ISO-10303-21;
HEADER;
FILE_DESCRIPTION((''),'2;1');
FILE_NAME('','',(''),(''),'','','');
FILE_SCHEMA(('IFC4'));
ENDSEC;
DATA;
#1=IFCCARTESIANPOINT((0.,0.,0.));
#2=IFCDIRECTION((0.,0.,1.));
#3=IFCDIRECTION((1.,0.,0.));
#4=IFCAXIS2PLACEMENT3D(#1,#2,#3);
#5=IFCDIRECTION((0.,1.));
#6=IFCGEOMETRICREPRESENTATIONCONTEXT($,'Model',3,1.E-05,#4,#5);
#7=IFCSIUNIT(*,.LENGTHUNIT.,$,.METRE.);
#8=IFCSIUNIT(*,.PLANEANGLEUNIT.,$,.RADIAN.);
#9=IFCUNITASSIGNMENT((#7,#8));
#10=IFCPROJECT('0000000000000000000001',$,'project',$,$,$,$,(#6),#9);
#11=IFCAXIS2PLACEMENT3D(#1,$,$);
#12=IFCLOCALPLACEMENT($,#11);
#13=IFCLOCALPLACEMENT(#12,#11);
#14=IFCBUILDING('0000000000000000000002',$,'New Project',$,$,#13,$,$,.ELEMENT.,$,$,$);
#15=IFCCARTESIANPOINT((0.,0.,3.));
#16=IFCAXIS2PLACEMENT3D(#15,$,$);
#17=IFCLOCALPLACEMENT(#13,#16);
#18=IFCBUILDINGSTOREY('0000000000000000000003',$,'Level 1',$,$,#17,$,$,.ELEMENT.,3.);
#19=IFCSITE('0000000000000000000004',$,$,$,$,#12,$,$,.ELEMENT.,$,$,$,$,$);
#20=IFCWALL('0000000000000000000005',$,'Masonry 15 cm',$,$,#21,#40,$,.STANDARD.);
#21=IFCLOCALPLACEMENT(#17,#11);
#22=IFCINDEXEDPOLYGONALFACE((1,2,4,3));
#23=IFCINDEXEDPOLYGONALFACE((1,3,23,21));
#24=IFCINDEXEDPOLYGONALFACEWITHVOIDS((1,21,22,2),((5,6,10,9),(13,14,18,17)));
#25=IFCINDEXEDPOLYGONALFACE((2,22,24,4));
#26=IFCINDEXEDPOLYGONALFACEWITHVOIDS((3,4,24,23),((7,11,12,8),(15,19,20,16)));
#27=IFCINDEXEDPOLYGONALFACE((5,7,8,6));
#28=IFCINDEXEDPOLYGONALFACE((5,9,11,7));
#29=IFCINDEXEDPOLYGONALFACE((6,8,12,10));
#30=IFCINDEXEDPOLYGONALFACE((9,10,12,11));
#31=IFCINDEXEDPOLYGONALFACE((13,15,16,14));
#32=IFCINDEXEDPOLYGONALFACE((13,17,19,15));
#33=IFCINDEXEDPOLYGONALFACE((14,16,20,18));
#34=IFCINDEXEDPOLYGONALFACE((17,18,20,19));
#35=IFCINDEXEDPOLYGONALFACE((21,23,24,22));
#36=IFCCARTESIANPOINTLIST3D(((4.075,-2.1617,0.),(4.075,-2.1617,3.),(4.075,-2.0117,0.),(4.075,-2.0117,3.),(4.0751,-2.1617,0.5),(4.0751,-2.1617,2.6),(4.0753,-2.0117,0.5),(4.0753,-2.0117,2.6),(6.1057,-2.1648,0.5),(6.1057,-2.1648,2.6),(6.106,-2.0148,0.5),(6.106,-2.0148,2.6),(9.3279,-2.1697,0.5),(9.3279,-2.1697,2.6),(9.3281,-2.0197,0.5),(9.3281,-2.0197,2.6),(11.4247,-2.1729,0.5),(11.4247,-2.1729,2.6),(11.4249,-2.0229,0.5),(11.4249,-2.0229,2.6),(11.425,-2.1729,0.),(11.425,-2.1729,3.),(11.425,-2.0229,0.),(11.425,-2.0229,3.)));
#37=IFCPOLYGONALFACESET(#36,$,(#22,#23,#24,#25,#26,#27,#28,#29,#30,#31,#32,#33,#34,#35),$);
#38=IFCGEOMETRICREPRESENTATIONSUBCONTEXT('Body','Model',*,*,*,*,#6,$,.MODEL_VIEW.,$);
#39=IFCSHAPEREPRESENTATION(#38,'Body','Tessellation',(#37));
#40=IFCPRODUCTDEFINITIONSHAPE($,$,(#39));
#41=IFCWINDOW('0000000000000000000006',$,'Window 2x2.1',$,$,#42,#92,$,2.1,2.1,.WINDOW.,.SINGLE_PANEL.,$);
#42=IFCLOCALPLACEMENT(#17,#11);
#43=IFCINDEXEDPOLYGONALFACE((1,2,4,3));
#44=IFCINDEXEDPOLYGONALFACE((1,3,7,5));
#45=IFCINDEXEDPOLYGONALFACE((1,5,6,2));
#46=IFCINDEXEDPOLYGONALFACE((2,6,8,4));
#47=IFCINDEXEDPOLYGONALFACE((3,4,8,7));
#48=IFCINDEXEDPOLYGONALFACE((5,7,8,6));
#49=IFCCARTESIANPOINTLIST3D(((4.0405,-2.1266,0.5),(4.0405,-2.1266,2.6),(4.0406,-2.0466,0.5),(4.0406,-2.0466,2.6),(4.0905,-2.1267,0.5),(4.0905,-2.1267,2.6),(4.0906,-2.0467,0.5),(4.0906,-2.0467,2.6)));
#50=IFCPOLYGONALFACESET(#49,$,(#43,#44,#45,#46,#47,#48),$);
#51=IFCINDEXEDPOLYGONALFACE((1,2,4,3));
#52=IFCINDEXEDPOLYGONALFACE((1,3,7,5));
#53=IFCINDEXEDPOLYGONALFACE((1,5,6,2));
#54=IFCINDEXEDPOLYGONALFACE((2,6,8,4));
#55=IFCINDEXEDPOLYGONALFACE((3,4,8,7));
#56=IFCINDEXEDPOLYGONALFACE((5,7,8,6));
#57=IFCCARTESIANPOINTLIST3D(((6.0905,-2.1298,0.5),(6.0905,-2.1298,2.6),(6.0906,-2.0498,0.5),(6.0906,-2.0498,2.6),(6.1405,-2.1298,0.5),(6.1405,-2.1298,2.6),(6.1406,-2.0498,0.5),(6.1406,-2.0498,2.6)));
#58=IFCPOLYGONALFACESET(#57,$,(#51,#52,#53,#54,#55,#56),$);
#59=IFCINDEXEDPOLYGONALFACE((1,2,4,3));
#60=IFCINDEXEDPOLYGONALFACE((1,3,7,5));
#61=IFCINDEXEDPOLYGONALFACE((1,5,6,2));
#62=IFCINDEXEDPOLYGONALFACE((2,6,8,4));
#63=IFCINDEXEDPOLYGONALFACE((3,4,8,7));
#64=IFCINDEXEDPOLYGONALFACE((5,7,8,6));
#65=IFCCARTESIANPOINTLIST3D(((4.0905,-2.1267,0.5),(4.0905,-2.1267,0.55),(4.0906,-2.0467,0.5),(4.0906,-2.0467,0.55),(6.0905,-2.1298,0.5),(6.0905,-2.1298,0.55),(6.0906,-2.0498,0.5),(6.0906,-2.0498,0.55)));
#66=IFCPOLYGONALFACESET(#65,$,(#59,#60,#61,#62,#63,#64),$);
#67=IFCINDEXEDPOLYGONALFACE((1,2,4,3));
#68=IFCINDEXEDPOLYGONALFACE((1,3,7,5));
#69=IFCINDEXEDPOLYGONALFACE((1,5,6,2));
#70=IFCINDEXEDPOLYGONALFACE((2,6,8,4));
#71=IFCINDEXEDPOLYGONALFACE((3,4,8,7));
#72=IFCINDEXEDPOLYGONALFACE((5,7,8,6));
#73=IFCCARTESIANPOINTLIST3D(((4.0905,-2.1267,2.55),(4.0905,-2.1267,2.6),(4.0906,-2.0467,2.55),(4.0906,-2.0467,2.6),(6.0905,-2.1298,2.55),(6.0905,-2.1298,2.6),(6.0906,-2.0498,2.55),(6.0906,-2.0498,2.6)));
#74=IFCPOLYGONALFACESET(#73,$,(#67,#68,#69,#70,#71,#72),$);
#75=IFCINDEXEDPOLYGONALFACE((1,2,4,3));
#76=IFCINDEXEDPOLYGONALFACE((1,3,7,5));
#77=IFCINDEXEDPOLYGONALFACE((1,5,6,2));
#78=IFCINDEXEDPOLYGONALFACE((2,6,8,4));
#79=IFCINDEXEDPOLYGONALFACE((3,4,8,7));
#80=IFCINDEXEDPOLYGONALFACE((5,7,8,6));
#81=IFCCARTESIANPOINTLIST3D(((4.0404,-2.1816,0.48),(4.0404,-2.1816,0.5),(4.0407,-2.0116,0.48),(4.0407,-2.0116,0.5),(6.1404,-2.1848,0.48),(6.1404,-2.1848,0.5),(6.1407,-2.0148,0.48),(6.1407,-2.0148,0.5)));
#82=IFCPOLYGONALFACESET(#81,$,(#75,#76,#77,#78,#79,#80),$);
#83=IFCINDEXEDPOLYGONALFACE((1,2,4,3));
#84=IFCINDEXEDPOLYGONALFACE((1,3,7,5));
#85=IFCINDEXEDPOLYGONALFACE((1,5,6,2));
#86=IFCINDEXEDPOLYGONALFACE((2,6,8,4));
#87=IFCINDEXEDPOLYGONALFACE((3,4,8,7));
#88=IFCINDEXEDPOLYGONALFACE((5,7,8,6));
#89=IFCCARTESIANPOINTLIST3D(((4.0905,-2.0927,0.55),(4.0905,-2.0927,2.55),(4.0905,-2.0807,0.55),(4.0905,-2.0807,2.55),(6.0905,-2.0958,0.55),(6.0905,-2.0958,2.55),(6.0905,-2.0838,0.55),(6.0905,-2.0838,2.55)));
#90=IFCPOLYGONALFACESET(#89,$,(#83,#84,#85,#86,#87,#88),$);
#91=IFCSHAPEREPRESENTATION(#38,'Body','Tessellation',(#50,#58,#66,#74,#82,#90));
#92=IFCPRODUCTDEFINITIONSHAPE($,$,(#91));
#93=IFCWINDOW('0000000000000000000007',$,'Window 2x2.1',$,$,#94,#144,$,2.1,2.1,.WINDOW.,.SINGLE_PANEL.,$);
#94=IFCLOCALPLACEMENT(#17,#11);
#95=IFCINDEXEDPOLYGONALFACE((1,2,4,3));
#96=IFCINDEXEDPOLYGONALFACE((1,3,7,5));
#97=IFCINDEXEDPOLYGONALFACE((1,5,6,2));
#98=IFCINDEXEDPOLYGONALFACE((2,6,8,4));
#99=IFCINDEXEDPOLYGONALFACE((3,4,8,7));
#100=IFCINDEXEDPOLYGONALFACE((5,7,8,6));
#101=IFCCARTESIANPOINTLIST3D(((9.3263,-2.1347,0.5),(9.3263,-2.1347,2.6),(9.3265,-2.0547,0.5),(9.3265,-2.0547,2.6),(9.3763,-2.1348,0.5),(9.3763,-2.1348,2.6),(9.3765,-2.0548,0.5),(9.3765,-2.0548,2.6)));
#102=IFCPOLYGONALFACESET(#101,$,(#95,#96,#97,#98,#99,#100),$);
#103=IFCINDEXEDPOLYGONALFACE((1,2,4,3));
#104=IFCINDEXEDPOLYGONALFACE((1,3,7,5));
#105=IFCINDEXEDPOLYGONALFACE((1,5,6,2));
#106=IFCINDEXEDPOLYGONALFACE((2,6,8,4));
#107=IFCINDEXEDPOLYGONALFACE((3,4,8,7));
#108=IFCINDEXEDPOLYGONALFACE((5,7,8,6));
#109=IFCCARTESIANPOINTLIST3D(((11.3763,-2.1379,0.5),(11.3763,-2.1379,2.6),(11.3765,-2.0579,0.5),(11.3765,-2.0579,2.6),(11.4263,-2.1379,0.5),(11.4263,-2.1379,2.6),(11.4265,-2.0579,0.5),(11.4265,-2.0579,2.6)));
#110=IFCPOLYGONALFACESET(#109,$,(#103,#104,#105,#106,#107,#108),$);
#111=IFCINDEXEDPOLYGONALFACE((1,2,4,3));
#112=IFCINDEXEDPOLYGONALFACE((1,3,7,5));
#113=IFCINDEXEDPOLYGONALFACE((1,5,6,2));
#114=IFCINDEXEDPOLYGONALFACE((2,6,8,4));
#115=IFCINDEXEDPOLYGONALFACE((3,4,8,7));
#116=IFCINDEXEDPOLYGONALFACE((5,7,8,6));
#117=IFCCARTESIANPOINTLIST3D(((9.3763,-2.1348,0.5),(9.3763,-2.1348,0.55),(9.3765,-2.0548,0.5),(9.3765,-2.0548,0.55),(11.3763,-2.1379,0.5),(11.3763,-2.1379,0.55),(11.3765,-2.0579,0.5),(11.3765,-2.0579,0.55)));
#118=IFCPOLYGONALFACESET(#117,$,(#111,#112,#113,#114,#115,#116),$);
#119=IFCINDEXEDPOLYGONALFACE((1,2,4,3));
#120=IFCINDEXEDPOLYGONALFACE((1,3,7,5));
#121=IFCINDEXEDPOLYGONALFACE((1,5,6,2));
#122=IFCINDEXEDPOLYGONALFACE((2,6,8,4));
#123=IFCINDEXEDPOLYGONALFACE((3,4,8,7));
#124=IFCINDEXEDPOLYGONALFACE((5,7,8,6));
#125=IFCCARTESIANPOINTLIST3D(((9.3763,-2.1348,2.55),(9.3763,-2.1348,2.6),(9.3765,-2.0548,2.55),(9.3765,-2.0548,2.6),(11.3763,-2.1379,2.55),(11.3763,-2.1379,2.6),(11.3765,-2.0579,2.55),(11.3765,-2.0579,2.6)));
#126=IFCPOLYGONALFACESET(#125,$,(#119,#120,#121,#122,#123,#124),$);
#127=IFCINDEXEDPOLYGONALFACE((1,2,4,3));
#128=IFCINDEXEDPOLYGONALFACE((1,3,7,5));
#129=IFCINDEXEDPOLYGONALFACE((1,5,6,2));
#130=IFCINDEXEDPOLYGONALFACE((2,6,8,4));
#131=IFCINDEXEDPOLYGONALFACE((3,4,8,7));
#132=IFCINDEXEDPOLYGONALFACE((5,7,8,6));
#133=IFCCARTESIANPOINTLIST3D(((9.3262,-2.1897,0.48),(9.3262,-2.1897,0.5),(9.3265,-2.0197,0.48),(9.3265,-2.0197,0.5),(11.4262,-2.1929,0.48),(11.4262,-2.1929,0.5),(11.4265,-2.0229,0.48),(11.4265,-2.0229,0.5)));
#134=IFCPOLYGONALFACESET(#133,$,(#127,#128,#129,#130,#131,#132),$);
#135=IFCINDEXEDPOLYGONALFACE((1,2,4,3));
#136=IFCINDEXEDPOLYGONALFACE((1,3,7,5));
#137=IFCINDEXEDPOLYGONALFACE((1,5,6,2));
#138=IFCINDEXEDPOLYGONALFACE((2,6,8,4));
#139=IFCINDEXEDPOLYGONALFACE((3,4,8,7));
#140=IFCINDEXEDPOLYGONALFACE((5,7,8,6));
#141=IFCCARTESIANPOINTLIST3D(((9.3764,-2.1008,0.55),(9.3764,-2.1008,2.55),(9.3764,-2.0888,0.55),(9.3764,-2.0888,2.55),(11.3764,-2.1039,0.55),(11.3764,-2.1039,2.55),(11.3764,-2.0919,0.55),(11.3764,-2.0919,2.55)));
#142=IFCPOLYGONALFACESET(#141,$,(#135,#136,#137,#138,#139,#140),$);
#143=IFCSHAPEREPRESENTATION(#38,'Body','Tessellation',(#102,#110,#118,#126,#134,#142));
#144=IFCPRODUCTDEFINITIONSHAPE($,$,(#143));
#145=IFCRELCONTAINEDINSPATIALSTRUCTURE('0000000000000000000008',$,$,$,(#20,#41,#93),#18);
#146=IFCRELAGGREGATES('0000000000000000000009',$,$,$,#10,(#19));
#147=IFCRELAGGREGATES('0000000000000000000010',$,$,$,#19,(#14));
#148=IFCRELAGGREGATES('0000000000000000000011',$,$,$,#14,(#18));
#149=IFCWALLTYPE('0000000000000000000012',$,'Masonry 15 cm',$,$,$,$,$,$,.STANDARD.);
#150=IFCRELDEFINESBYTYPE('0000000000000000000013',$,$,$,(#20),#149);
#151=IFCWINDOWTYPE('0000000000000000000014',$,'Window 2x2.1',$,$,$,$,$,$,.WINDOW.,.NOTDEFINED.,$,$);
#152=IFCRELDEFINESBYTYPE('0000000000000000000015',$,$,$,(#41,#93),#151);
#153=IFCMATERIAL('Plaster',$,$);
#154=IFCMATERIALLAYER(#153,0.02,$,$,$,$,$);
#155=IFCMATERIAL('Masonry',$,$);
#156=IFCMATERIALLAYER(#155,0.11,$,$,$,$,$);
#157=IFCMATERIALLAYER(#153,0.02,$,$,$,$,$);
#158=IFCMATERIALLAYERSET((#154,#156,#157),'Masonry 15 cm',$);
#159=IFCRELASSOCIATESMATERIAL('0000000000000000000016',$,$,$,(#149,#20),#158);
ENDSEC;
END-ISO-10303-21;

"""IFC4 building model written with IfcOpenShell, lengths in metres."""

from ifc_helpers import new_model, si_unit, direction, frame, frame_2d, origin, origin_with_axes, place, context, subcontext, project, spatial, polyline, rectangle, outline, extrude, material, layer, layer_set, layer_usage, type_object, element, fill, save


model = new_model("IFC4")

# Units and contexts
model_context = context("Model", 3, precision=1e-05, world=origin_with_axes(), true_north=direction((0.0, 1.0)))
body_context = subcontext(model_context, "Body", "Model", "MODEL_VIEW")
ifc_project = project(units=[si_unit("LENGTHUNIT", "METRE"), si_unit("PLANEANGLEUNIT", "RADIAN")], contexts=[model_context])

# Site, building, storey
site_placement = place(None, origin())
site = spatial("IfcSite", under=ifc_project, at=site_placement, CompositionType="ELEMENT")
building_placement = place(site_placement, origin())
building = spatial("IfcBuilding", under=site, at=building_placement, Name="New Project", CompositionType="ELEMENT")
storey_placement = place(building_placement, frame((0.0, 0.0, 3.0)))
storey = spatial("IfcBuildingStorey", under=building, at=storey_placement, Name="Level 1", CompositionType="ELEMENT", Elevation=3.0)

# Shared definitions
ifc_material_1 = material(Name="Plaster")
ifc_layer_1 = layer(ifc_material_1, 0.02)
ifc_material_2 = material(Name="Masonry")
ifc_layer_2 = layer(ifc_material_2, 0.11)
ifc_layer_3 = layer(ifc_material_1, 0.02)
ifc_layer_set_1 = layer_set([ifc_layer_1, ifc_layer_2, ifc_layer_3], Name="Masonry 15 cm")
ifc_layer_usage_1 = layer_usage(ifc_layer_set_1, "AXIS2", "NEGATIVE", 0.075)
wall_type_1 = type_object("IfcWallType", Name="Masonry 15 cm", PredefinedType="STANDARD", material=ifc_layer_set_1)

# Wall, openings, windows
wall_1_placement = place(storey_placement, frame((11.425, -2.0979, 0.0), z_axis=(0.0, 0.0, 1.0), x_axis=(-0.999999, 0.001534, 0.0)))
wall_1 = element("IfcWall", 1, at=wall_1_placement, inside=storey, type_object=wall_type_1, material=ifc_layer_usage_1, Name="Masonry 15 cm", PredefinedType="STANDARD", context=body_context, shape_type="SweptSolid", body=[
    extrude(outline(polyline([(0.0001, -0.075), (7.3501, -0.075), (7.3499, 0.075), (-0.0001, 0.075), (0.0001, -0.075)])), origin(), (0.0, 0.0, 1.0), 3.0),
])
opening_1_placement = place(wall_1_placement, frame((5.3191, 0.0, 0.5)))
opening_1 = element("IfcOpeningElement", 2, at=opening_1_placement, cuts=wall_1, PredefinedType="OPENING", context=body_context, shape_type="SweptSolid", body=[
    extrude(rectangle(XDim=2.0306, YDim=0.25, at=frame_2d((1.0153, 0.0))), origin(), (0.0, 0.0, 1.0), 2.1),
])
opening_2_placement = place(wall_1_placement, frame((0.0002, 0.0, 0.5)))
opening_2 = element("IfcOpeningElement", 3, at=opening_2_placement, cuts=wall_1, PredefinedType="OPENING", context=body_context, shape_type="SweptSolid", body=[
    extrude(rectangle(XDim=2.0968, YDim=0.25, at=frame_2d((1.0484, 0.0))), origin(), (0.0, 0.0, 1.0), 2.1),
])
window_type_1 = type_object("IfcWindowType", Name="Window 2x2.1", PartitioningType="NOTDEFINED", PredefinedType="WINDOW")
window_1_placement = place(opening_1_placement, origin())
window_1 = element("IfcWindow", 4, at=window_1_placement, inside=storey, type_object=window_type_1, Name="Window 2x2.1", OverallHeight=2.1, OverallWidth=2.1, PartitioningType="SINGLE_PANEL", PredefinedType="WINDOW", context=body_context, shape_type="SweptSolid", body=[
    extrude(outline(polyline([(2.0653, 0.04), (2.0153, 0.04), (2.0153, -0.04), (2.0653, -0.04), (2.0653, 0.04)])), origin(), (0.0, 0.0, 1.0), 2.1),
    extrude(outline(polyline([(0.0153, 0.04), (-0.0347, 0.04), (-0.0347, -0.04), (0.0153, -0.04), (0.0153, 0.04)])), origin(), (0.0, 0.0, 1.0), 2.1),
    extrude(outline(polyline([(2.0153, 0.04), (0.0153, 0.04), (0.0153, -0.04), (2.0153, -0.04), (2.0153, 0.04)])), origin(), (0.0, 0.0, 1.0), 0.05),
    extrude(outline(polyline([(2.0153, 0.04), (0.0153, 0.04), (0.0153, -0.04), (2.0153, -0.04), (2.0153, 0.04)])), frame((0.0, 0.0, 2.05)), (0.0, 0.0, 1.0), 0.05),
    extrude(outline(polyline([(2.0653, 0.095), (-0.0347, 0.095), (-0.0347, -0.075), (2.0653, -0.075), (2.0653, 0.095)])), frame((0.0, 0.0, -0.02)), (0.0, 0.0, 1.0), 0.02),
    extrude(outline(polyline([(2.0153, 0.006), (0.0153, 0.006), (0.0153, -0.006), (2.0153, -0.006), (2.0153, 0.006)])), frame((0.0, 0.0, 0.05)), (0.0, 0.0, 1.0), 2.0),
])
fill(opening_1, window_1)
window_2_placement = place(opening_2_placement, origin())
window_2 = element("IfcWindow", 5, at=window_2_placement, inside=storey, type_object=window_type_1, Name="Window 2x2.1", OverallHeight=2.1, OverallWidth=2.1, PartitioningType="SINGLE_PANEL", PredefinedType="WINDOW", context=body_context, shape_type="SweptSolid", body=[
    extrude(outline(polyline([(2.0984, 0.04), (2.0484, 0.04), (2.0484, -0.04), (2.0984, -0.04), (2.0984, 0.04)])), origin(), (0.0, 0.0, 1.0), 2.1),
    extrude(outline(polyline([(0.0484, 0.04), (-0.0016, 0.04), (-0.0016, -0.04), (0.0484, -0.04), (0.0484, 0.04)])), origin(), (0.0, 0.0, 1.0), 2.1),
    extrude(outline(polyline([(2.0484, 0.04), (0.0484, 0.04), (0.0484, -0.04), (2.0484, -0.04), (2.0484, 0.04)])), origin(), (0.0, 0.0, 1.0), 0.05),
    extrude(outline(polyline([(2.0484, 0.04), (0.0484, 0.04), (0.0484, -0.04), (2.0484, -0.04), (2.0484, 0.04)])), frame((0.0, 0.0, 2.05)), (0.0, 0.0, 1.0), 0.05),
    extrude(outline(polyline([(2.0984, 0.095), (-0.0016, 0.095), (-0.0016, -0.075), (2.0984, -0.075), (2.0984, 0.095)])), frame((0.0, 0.0, -0.02)), (0.0, 0.0, 1.0), 0.02),
    extrude(outline(polyline([(2.0484, 0.006), (0.0484, 0.006), (0.0484, -0.006), (2.0484, -0.006), (2.0484, 0.006)])), frame((0.0, 0.0, 0.05)), (0.0, 0.0, 1.0), 2.0),
])
fill(opening_2, window_2)

save(model, "model.ifc")
